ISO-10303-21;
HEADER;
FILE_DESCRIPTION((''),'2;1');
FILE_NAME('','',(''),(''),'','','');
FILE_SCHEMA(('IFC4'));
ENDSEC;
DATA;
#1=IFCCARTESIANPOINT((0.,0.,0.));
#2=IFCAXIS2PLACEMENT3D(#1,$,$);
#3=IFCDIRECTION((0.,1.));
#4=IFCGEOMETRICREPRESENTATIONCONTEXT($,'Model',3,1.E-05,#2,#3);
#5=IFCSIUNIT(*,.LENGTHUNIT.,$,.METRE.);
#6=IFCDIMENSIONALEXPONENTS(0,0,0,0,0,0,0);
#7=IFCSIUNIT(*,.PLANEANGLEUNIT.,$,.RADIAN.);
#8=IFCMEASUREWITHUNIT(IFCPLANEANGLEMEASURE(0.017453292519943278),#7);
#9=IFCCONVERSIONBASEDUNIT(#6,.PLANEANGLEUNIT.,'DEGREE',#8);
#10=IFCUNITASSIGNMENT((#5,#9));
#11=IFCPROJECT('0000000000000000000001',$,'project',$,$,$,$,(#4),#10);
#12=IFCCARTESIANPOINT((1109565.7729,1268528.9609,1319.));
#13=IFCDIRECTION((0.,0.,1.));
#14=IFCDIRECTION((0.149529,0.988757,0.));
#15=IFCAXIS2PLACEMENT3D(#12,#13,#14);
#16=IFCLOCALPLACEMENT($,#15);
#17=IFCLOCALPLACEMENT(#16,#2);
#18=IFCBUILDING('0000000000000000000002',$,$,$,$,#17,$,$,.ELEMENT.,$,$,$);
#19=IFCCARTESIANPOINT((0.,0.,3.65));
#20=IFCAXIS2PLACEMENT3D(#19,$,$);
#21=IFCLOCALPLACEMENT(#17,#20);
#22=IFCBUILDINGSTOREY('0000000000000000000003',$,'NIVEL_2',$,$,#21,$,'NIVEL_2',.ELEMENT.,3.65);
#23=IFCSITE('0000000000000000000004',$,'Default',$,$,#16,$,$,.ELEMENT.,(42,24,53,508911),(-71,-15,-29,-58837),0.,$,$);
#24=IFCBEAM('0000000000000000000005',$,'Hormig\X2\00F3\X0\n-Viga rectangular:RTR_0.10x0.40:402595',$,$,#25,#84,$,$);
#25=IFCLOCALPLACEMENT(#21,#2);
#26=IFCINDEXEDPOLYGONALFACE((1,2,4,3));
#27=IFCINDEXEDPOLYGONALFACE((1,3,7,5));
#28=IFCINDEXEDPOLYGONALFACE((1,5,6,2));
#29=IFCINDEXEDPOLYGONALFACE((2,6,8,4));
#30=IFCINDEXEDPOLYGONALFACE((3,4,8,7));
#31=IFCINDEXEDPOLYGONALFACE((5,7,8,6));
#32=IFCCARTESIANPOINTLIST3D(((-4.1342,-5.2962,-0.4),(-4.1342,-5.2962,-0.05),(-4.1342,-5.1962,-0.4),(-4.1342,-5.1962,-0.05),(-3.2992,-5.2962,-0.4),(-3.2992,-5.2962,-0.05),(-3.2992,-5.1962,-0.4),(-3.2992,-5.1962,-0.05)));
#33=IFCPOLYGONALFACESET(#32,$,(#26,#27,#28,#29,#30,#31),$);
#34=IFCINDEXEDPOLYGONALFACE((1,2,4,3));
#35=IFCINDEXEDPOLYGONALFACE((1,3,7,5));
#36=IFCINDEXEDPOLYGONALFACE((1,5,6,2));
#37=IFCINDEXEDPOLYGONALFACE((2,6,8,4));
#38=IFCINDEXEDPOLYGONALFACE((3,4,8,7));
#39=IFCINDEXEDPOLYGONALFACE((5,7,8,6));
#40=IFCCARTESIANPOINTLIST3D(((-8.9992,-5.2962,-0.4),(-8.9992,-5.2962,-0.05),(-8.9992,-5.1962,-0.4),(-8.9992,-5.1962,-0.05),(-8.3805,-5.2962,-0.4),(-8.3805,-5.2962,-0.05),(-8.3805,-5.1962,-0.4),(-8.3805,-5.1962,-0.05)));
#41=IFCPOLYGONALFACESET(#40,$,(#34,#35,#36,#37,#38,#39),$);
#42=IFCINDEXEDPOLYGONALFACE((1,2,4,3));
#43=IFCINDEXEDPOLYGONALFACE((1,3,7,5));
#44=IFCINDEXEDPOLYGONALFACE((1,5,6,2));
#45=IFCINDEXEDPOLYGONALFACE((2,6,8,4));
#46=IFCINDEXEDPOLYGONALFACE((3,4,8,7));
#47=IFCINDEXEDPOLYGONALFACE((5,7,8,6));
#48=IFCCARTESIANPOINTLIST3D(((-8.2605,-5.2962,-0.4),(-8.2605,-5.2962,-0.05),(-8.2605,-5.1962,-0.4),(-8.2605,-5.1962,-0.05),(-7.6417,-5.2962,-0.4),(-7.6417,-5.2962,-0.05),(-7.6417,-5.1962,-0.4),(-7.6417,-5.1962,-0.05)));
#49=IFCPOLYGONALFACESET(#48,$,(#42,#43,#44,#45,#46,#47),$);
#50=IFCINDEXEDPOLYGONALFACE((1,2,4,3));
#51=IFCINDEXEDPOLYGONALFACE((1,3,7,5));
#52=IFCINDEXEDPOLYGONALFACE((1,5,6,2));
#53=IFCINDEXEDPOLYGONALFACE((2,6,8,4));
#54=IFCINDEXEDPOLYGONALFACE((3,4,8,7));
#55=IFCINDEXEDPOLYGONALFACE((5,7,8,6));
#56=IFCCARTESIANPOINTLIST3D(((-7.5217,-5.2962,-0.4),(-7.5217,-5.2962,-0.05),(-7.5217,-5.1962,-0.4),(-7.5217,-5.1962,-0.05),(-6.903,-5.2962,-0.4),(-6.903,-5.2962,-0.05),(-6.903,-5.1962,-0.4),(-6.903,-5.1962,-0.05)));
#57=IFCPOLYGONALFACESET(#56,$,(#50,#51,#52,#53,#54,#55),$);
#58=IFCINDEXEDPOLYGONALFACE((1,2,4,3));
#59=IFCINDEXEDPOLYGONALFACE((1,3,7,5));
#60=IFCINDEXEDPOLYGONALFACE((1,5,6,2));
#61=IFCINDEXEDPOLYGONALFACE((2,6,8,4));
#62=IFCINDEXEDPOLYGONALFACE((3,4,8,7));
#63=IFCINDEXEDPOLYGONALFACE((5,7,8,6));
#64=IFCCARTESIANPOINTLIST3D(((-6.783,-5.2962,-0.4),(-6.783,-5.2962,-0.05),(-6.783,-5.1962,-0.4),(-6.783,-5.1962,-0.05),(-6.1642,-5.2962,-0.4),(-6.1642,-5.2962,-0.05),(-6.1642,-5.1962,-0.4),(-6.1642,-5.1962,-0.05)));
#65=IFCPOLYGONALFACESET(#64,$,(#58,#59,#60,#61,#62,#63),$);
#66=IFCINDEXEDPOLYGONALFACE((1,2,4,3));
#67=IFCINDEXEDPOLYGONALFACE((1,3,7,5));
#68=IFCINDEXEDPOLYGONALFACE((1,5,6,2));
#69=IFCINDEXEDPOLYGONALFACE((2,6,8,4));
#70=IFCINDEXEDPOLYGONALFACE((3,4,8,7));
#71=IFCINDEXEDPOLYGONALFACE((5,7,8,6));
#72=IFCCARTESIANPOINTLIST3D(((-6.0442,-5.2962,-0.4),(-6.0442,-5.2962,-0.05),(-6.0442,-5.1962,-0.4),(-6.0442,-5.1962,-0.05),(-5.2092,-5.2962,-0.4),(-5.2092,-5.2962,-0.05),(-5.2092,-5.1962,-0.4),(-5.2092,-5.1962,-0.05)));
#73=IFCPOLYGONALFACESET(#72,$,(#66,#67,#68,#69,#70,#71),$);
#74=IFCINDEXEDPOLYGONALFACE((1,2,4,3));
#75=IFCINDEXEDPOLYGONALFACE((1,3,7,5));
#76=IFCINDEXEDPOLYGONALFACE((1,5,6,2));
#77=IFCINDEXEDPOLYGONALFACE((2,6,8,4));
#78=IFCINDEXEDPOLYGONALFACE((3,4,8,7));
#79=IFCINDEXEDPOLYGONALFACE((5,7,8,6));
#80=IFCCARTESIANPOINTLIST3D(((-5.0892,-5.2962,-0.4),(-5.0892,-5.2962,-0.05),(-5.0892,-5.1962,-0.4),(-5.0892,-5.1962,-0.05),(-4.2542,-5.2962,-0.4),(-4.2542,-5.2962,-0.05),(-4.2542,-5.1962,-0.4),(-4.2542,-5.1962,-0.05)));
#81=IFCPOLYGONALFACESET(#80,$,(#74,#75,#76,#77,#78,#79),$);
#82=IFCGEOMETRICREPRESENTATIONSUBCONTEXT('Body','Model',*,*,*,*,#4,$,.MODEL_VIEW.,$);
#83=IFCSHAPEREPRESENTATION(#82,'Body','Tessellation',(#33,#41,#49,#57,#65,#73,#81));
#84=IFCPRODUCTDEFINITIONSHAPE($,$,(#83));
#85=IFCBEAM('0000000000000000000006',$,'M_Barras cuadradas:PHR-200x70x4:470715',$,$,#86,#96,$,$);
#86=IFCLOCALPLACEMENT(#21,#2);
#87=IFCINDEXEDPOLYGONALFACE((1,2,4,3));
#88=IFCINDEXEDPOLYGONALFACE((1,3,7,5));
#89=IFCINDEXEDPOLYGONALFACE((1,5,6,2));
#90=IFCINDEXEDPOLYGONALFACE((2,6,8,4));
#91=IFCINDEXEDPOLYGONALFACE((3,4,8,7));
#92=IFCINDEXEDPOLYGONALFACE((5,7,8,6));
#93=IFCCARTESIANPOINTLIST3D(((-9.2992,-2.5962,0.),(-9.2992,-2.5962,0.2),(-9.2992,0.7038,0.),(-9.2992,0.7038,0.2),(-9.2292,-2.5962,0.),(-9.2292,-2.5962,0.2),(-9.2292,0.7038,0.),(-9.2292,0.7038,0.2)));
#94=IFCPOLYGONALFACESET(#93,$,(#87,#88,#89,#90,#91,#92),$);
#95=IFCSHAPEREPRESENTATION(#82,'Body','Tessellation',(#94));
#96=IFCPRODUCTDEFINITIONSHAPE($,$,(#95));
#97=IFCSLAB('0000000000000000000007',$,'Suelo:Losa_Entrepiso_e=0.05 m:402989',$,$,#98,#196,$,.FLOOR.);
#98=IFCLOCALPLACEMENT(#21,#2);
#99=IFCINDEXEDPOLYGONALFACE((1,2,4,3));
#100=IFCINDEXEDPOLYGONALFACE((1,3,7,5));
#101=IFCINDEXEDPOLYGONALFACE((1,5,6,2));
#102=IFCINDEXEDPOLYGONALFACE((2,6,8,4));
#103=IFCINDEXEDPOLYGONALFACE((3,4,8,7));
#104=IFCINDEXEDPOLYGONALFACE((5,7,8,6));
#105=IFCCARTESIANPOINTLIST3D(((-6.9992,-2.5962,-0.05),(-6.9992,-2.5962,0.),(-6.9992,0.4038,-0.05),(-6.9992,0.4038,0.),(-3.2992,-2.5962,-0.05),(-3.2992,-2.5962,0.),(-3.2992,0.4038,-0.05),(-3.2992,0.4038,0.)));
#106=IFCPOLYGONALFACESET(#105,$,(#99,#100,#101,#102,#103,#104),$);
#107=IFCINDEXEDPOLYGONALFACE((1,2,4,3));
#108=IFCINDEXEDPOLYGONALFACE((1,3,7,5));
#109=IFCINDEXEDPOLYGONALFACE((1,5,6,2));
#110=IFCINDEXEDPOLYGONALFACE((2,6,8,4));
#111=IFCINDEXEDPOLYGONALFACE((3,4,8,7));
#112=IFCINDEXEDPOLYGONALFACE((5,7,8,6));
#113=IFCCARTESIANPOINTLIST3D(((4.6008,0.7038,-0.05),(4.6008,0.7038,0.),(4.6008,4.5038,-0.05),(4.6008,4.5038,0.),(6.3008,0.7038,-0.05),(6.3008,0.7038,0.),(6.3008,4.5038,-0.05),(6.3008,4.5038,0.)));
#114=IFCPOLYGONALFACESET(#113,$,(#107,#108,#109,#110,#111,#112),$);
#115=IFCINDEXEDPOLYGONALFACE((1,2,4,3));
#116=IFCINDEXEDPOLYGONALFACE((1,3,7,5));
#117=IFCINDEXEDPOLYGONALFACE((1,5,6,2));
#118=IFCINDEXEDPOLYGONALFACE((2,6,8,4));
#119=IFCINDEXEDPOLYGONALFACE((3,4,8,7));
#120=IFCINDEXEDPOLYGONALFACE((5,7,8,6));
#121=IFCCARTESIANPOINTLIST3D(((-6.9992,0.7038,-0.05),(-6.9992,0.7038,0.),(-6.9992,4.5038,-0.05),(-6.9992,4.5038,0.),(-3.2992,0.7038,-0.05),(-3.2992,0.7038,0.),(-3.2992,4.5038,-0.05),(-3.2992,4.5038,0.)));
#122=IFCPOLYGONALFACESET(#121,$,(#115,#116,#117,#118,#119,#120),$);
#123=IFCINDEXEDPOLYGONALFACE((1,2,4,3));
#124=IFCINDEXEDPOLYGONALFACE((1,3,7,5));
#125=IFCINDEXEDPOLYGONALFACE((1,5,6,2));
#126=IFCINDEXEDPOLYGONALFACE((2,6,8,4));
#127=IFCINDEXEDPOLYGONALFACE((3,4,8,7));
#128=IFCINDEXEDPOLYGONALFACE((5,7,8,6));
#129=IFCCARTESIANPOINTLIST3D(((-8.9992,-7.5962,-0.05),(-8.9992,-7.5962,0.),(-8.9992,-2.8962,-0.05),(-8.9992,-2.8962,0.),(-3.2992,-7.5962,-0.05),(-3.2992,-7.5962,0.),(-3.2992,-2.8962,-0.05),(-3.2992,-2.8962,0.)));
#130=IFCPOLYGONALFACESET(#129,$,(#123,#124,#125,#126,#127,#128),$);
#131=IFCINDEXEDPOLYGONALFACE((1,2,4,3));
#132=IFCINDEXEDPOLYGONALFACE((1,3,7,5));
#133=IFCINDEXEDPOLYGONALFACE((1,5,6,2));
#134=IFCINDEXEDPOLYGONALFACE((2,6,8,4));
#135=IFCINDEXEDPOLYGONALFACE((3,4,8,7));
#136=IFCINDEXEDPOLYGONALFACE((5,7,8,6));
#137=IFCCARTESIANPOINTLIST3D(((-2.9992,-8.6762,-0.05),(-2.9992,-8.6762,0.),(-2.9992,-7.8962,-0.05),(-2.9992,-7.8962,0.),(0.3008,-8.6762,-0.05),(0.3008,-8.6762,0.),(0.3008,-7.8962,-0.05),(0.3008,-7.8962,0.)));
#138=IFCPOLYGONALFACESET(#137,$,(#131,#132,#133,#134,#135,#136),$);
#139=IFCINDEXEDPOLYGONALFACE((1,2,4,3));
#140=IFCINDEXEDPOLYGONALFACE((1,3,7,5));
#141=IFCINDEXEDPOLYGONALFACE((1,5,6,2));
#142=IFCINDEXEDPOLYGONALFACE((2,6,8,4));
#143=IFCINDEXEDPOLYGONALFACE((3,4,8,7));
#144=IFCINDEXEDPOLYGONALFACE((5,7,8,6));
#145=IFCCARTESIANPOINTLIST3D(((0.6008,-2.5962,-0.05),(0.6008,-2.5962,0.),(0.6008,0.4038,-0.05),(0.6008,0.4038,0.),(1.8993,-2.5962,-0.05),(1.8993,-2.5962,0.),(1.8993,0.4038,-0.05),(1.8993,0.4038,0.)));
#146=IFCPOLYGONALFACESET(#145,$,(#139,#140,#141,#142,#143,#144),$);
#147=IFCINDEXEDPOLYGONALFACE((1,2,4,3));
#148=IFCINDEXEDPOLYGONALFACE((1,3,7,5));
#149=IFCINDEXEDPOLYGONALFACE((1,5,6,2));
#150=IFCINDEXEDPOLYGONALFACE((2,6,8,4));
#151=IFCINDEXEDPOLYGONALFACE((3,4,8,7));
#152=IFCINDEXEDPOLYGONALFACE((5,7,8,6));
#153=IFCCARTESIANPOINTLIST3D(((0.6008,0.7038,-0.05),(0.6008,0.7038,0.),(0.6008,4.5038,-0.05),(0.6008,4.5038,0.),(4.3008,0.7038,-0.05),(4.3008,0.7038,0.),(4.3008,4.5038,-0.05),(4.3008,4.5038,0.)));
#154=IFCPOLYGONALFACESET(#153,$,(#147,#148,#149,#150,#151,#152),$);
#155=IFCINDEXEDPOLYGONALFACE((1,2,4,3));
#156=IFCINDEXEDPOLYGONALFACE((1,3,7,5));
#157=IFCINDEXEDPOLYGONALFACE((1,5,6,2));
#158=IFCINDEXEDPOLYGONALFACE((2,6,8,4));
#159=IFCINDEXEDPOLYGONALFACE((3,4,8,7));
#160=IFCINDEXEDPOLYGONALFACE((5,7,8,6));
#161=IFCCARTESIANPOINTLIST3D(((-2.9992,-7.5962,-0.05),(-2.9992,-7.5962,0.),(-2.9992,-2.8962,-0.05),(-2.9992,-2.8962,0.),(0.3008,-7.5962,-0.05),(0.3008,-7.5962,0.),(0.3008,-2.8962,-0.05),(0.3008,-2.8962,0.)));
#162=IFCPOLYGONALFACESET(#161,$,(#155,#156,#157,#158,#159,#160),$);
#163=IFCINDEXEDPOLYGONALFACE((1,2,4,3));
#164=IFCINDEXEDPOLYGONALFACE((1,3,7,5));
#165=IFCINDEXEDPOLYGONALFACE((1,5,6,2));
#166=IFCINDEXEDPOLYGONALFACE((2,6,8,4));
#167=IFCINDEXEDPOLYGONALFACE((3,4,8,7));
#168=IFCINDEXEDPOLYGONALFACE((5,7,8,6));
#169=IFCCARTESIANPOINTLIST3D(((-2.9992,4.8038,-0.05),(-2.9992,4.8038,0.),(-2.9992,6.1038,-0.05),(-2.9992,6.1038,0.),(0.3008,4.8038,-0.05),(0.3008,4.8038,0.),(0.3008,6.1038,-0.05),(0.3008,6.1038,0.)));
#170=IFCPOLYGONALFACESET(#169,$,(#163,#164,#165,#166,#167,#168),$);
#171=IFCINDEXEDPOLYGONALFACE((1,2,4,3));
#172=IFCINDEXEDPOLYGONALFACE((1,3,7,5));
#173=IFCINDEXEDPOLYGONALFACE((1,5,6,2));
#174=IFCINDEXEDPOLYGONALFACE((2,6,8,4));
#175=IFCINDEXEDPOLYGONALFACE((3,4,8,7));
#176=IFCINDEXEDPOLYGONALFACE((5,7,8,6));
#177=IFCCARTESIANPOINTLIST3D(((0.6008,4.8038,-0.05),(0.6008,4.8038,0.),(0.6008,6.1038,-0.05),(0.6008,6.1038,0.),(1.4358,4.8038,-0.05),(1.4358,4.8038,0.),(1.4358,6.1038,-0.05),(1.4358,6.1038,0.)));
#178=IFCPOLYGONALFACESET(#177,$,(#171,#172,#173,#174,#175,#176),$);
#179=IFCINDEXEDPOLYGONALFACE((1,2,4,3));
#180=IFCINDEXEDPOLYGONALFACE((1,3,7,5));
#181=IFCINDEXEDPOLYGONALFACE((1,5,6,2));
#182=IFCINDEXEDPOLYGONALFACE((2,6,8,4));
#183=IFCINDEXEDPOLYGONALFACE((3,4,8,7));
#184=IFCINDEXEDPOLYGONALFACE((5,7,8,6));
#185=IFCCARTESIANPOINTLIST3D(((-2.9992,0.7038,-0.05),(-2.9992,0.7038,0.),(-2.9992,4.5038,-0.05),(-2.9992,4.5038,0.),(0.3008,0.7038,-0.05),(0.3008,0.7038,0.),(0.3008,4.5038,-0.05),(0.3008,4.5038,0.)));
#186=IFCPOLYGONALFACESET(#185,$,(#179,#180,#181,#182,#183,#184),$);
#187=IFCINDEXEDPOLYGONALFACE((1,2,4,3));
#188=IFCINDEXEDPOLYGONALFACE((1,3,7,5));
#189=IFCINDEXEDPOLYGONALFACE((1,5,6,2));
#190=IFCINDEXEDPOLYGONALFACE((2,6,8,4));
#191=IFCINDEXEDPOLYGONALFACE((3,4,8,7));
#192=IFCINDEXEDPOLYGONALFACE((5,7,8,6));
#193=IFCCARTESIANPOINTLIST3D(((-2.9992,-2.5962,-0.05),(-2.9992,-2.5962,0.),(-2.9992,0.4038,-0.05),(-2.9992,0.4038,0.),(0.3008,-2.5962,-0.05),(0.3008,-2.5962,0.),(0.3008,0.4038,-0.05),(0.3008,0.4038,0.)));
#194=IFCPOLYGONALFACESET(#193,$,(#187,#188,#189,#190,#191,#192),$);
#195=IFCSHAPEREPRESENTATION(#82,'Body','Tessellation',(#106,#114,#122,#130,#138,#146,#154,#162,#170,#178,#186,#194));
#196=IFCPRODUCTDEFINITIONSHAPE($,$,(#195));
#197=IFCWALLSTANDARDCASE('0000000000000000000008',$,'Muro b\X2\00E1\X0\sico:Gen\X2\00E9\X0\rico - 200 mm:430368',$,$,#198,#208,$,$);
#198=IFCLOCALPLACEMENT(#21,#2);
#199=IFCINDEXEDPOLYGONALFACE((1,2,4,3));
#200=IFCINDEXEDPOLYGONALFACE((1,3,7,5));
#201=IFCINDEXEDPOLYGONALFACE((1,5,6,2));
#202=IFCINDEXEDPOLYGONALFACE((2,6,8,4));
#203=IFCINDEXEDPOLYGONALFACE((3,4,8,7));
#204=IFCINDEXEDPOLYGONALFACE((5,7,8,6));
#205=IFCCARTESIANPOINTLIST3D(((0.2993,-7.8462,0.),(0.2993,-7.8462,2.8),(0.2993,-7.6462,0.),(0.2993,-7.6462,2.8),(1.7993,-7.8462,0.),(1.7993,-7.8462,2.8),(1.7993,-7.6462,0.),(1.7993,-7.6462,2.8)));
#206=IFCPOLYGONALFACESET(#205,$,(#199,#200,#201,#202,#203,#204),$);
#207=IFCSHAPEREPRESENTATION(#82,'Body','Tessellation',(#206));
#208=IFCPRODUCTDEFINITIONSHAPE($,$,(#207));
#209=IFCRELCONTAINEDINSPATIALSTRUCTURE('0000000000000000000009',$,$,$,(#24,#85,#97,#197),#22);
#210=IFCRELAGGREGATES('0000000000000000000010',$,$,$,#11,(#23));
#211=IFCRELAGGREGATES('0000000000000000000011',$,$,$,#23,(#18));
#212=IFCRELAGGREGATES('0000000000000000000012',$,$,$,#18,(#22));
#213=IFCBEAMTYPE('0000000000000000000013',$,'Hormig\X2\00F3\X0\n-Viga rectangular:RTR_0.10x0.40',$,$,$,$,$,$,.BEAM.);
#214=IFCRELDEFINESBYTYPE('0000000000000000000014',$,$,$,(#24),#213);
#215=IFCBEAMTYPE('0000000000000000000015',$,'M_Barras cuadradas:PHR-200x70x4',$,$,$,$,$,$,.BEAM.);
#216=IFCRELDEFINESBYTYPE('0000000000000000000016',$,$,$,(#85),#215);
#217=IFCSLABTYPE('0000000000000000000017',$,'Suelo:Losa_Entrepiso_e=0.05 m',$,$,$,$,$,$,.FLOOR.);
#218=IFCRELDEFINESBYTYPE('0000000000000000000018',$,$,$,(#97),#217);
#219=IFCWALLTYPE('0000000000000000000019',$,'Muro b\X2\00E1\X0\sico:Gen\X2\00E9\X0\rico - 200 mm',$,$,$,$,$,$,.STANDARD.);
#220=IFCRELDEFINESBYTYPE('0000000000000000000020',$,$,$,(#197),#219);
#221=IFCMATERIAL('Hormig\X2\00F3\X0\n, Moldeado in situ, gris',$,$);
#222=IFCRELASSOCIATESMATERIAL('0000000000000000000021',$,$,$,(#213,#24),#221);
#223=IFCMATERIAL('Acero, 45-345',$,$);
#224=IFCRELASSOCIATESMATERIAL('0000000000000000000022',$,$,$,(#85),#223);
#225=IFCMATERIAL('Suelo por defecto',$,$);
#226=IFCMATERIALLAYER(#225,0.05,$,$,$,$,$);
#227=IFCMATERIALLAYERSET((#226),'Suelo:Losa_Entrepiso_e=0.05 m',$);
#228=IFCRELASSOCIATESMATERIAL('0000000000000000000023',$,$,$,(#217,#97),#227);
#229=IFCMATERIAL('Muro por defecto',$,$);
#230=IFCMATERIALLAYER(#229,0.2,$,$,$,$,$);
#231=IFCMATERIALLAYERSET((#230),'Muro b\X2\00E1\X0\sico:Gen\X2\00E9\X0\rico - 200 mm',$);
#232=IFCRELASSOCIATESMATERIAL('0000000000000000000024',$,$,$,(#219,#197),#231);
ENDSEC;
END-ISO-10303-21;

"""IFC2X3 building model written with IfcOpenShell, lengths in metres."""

from ifc_helpers import new_model, entity, si_unit, converted_unit, direction, frame, frame_2d, origin, place, context, subcontext, project, spatial, rectangle, extrude, source, transform, mapped, material, layer, layer_set, layer_usage, type_object, type_shapes, element, save


model = new_model("IFC2X3")

# Units and contexts
model_context = context("Model", 3, precision=1e-05, world=origin(), true_north=direction((0.0, 1.0)))
body_context = subcontext(model_context, "Body", "Model", "MODEL_VIEW")
ifc_project = project(units=[si_unit("LENGTHUNIT", "METRE"), converted_unit("PLANEANGLEUNIT", "DEGREE", entity("IfcPlaneAngleMeasure", 0.017453292519943278), si_unit("PLANEANGLEUNIT", "RADIAN"), dimensions=[0, 0, 0, 0, 0, 0, 0])], contexts=[model_context])

# Site, building, storey
site_placement = place(None, frame((1109565.7729, 1268528.9609, 1319.0), z_axis=(0.0, 0.0, 1.0), x_axis=(0.149529, 0.988757, 0.0)))
site = spatial("IfcSite", under=ifc_project, at=site_placement, Name="Default", CompositionType="ELEMENT", RefLatitude=(42, 24, 53, 508911), RefLongitude=(-71, -15, -29, -58837), RefElevation=0.0)
building_placement = place(site_placement, origin())
building = spatial("IfcBuilding", under=site, at=building_placement, CompositionType="ELEMENT")
storey_placement = place(building_placement, frame((0.0, 0.0, 3.65)))
storey = spatial("IfcBuildingStorey", under=building, at=storey_placement, Name="NIVEL_2", LongName="NIVEL_2", CompositionType="ELEMENT", Elevation=3.65)

# Shared definitions
ifc_material_1 = material(Name="Hormigón, Moldeado in situ, gris")

# Beams
beam_type_1 = type_object("IfcBeamType", Name="Hormigón-Viga rectangular:RTR_0.10x0.40", PredefinedType="BEAM", material=ifc_material_1)
shared_shape_1 = source(origin(), body_context, "Body", "SweptSolid", [
    extrude(rectangle(XDim=0.35, YDim=0.1, at=frame_2d((0.0, 0.0), x_axis=(1.0, 0.0))), frame((-4.1342, -5.2462, 3.425), z_axis=(1.0, 0.0, 0.0), x_axis=(0.0, 0.0, -1.0)), (0.0, 0.0, 1.0), 0.835),
    extrude(rectangle(XDim=0.35, YDim=0.1, at=frame_2d((0.0, 0.0), x_axis=(1.0, 0.0))), frame((-8.9992, -5.2462, 3.425), z_axis=(1.0, 0.0, 0.0), x_axis=(0.0, 0.0, -1.0)), (0.0, 0.0, 1.0), 0.6187),
    extrude(rectangle(XDim=0.35, YDim=0.1, at=frame_2d((0.0, 0.0), x_axis=(1.0, 0.0))), frame((-8.2605, -5.2462, 3.425), z_axis=(1.0, 0.0, 0.0), x_axis=(0.0, 0.0, -1.0)), (0.0, 0.0, 1.0), 0.6187),
    extrude(rectangle(XDim=0.35, YDim=0.1, at=frame_2d((0.0, 0.0), x_axis=(1.0, 0.0))), frame((-7.5217, -5.2462, 3.425), z_axis=(1.0, 0.0, 0.0), x_axis=(0.0, 0.0, -1.0)), (0.0, 0.0, 1.0), 0.6187),
    extrude(rectangle(XDim=0.35, YDim=0.1, at=frame_2d((0.0, 0.0), x_axis=(1.0, 0.0))), frame((-6.783, -5.2462, 3.425), z_axis=(1.0, 0.0, 0.0), x_axis=(0.0, 0.0, -1.0)), (0.0, 0.0, 1.0), 0.6187),
    extrude(rectangle(XDim=0.35, YDim=0.1, at=frame_2d((0.0, 0.0), x_axis=(1.0, 0.0))), frame((-6.0442, -5.2462, 3.425), z_axis=(1.0, 0.0, 0.0), x_axis=(0.0, 0.0, -1.0)), (0.0, 0.0, 1.0), 0.835),
    extrude(rectangle(XDim=0.35, YDim=0.1, at=frame_2d((0.0, 0.0), x_axis=(1.0, 0.0))), frame((-5.0892, -5.2462, 3.425), z_axis=(1.0, 0.0, 0.0), x_axis=(0.0, 0.0, -1.0)), (0.0, 0.0, 1.0), 0.835),
])
type_shapes(beam_type_1, [shared_shape_1])
beam_1_placement = place(storey_placement, frame((0.0, 0.0, -3.65)))
element("IfcBeam", 1, at=beam_1_placement, inside=storey, type_object=beam_type_1, material=ifc_material_1, Name="Hormigón-Viga rectangular:RTR_0.10x0.40:402595", context=body_context, shape_type="MappedRepresentation", body=[
    mapped(shared_shape_1, transform((0.0, 0.0, 0.0), scale=1.0)),
])
ifc_material_2 = material(Name="Acero, 45-345")
beam_type_2 = type_object("IfcBeamType", Name="M_Barras cuadradas:PHR-200x70x4", PredefinedType="BEAM")
beam_2_placement = place(storey_placement, frame((-9.2642, -2.5962, 0.0), z_axis=(0.0, 0.0, 1.0), x_axis=(0.0, 1.0, 0.0)))
element("IfcBeam", 2, at=beam_2_placement, inside=storey, type_object=beam_type_2, material=ifc_material_2, Name="M_Barras cuadradas:PHR-200x70x4:470715", context=body_context, shape_type="SweptSolid", body=[
    extrude(rectangle(XDim=0.2, YDim=0.07, at=frame_2d((0.0, 0.0), x_axis=(1.0, 0.0))), frame((0.0, 0.0, 0.1), z_axis=(1.0, 0.0, 0.0), x_axis=(0.0, 0.0, -1.0)), (0.0, 0.0, 1.0), 3.3),
])

# Slab
ifc_material_3 = material(Name="Suelo por defecto")
ifc_layer_1 = layer(ifc_material_3, 0.05)
ifc_layer_set_1 = layer_set([ifc_layer_1], Name="Suelo:Losa_Entrepiso_e=0.05 m")
ifc_layer_usage_1 = layer_usage(ifc_layer_set_1, "AXIS3", "POSITIVE", 0.0)
slab_type = type_object("IfcSlabType", Name="Suelo:Losa_Entrepiso_e=0.05 m", PredefinedType="FLOOR", material=ifc_layer_set_1)
slab_placement = place(storey_placement, origin())
element("IfcSlab", 3, at=slab_placement, inside=storey, type_object=slab_type, material=ifc_layer_usage_1, Name="Suelo:Losa_Entrepiso_e=0.05 m:402989", PredefinedType="FLOOR", context=body_context, shape_type="SweptSolid", body=[
    extrude(rectangle(XDim=3.0, YDim=3.7, at=frame_2d((0.0, 0.0), x_axis=(1.0, 0.0))), frame((-5.1492, -1.0962, -0.05), z_axis=(0.0, 0.0, 1.0), x_axis=(0.0, -1.0, 0.0)), (0.0, 0.0, 1.0), 0.05),
    extrude(rectangle(XDim=1.7, YDim=3.8, at=frame_2d((0.0, -0.05), x_axis=(1.0, 0.0))), frame((5.4508, 2.6538, -0.05)), (0.0, 0.0, 1.0), 0.05),
    extrude(rectangle(XDim=3.8, YDim=3.7, at=frame_2d((-0.03, 0.0), x_axis=(1.0, 0.0))), frame((-5.1492, 2.6338, -0.05), z_axis=(0.0, 0.0, 1.0), x_axis=(0.0, 1.0, 0.0)), (0.0, 0.0, 1.0), 0.05),
    extrude(rectangle(XDim=4.7, YDim=5.7, at=frame_2d((0.0, -0.1622), x_axis=(1.0, 0.0))), frame((-6.3114, -5.2462, -0.05), z_axis=(0.0, 0.0, 1.0), x_axis=(0.0, 1.0, 0.0)), (0.0, 0.0, 1.0), 0.05),
    extrude(rectangle(XDim=0.78, YDim=3.3, at=frame_2d((0.0, 0.0), x_axis=(1.0, 0.0))), frame((-1.3492, -8.2862, -0.05), z_axis=(0.0, 0.0, 1.0), x_axis=(0.0, -1.0, 0.0)), (0.0, 0.0, 1.0), 0.05),
    extrude(rectangle(XDim=3.0, YDim=1.2985, at=frame_2d((0.0, 0.0), x_axis=(1.0, 0.0))), frame((1.25, -1.0962, -0.05), z_axis=(0.0, 0.0, 1.0), x_axis=(0.0, 1.0, 0.0)), (0.0, 0.0, 1.0), 0.05),
    extrude(rectangle(XDim=3.7, YDim=3.8, at=frame_2d((-0.0365, -0.1455), x_axis=(1.0, 0.0))), frame((2.4143, 2.4583, -0.05), z_axis=(0.0, 0.0, 1.0), x_axis=(-1.0, 0.0, 0.0)), (0.0, 0.0, 1.0), 0.05),
    extrude(rectangle(XDim=4.7, YDim=3.3, at=frame_2d((-0.0097, 0.0), x_axis=(1.0, 0.0))), frame((-1.3492, -5.2559, -0.05), z_axis=(0.0, 0.0, 1.0), x_axis=(0.0, -1.0, 0.0)), (0.0, 0.0, 1.0), 0.05),
    extrude(rectangle(XDim=1.3, YDim=3.3, at=frame_2d((0.0, 0.0), x_axis=(1.0, 0.0))), frame((-1.3492, 5.4538, -0.05), z_axis=(0.0, 0.0, 1.0), x_axis=(0.0, 1.0, 0.0)), (0.0, 0.0, 1.0), 0.05),
    extrude(rectangle(XDim=0.835, YDim=1.3, at=frame_2d((0.0, 0.0), x_axis=(1.0, 0.0))), frame((1.0183, 5.4538, -0.05)), (0.0, 0.0, 1.0), 0.05),
    extrude(rectangle(XDim=3.8, YDim=3.3, at=frame_2d((-0.03, 0.0), x_axis=(1.0, 0.0))), frame((-1.3492, 2.6338, -0.05), z_axis=(0.0, 0.0, 1.0), x_axis=(0.0, 1.0, 0.0)), (0.0, 0.0, 1.0), 0.05),
    extrude(rectangle(XDim=3.0, YDim=3.3, at=frame_2d((0.0, 0.0), x_axis=(1.0, 0.0))), frame((-1.3492, -1.0962, -0.05), z_axis=(0.0, 0.0, 1.0), x_axis=(0.0, -1.0, 0.0)), (0.0, 0.0, 1.0), 0.05),
])

# Wall
ifc_material_4 = material(Name="Muro por defecto")
ifc_layer_2 = layer(ifc_material_4, 0.2)
ifc_layer_set_2 = layer_set([ifc_layer_2], Name="Muro básico:Genérico - 200 mm")
ifc_layer_usage_2 = layer_usage(ifc_layer_set_2, "AXIS2", "NEGATIVE", 0.1)
wall_type = type_object("IfcWallType", Name="Muro básico:Genérico - 200 mm", PredefinedType="STANDARD", material=ifc_layer_set_2)
wall_placement = place(storey_placement, frame((0.2993, -7.7462, 0.0)))
element("IfcWallStandardCase", 4, at=wall_placement, inside=storey, type_object=wall_type, material=ifc_layer_usage_2, Name="Muro básico:Genérico - 200 mm:430368", context=body_context, shape_type="SweptSolid", body=[
    extrude(rectangle(XDim=1.5, YDim=0.2, at=frame_2d((0.75, 0.0), x_axis=(-1.0, 0.0))), origin(), (0.0, 0.0, 1.0), 2.8),
])

save(model, "model.ifc")
